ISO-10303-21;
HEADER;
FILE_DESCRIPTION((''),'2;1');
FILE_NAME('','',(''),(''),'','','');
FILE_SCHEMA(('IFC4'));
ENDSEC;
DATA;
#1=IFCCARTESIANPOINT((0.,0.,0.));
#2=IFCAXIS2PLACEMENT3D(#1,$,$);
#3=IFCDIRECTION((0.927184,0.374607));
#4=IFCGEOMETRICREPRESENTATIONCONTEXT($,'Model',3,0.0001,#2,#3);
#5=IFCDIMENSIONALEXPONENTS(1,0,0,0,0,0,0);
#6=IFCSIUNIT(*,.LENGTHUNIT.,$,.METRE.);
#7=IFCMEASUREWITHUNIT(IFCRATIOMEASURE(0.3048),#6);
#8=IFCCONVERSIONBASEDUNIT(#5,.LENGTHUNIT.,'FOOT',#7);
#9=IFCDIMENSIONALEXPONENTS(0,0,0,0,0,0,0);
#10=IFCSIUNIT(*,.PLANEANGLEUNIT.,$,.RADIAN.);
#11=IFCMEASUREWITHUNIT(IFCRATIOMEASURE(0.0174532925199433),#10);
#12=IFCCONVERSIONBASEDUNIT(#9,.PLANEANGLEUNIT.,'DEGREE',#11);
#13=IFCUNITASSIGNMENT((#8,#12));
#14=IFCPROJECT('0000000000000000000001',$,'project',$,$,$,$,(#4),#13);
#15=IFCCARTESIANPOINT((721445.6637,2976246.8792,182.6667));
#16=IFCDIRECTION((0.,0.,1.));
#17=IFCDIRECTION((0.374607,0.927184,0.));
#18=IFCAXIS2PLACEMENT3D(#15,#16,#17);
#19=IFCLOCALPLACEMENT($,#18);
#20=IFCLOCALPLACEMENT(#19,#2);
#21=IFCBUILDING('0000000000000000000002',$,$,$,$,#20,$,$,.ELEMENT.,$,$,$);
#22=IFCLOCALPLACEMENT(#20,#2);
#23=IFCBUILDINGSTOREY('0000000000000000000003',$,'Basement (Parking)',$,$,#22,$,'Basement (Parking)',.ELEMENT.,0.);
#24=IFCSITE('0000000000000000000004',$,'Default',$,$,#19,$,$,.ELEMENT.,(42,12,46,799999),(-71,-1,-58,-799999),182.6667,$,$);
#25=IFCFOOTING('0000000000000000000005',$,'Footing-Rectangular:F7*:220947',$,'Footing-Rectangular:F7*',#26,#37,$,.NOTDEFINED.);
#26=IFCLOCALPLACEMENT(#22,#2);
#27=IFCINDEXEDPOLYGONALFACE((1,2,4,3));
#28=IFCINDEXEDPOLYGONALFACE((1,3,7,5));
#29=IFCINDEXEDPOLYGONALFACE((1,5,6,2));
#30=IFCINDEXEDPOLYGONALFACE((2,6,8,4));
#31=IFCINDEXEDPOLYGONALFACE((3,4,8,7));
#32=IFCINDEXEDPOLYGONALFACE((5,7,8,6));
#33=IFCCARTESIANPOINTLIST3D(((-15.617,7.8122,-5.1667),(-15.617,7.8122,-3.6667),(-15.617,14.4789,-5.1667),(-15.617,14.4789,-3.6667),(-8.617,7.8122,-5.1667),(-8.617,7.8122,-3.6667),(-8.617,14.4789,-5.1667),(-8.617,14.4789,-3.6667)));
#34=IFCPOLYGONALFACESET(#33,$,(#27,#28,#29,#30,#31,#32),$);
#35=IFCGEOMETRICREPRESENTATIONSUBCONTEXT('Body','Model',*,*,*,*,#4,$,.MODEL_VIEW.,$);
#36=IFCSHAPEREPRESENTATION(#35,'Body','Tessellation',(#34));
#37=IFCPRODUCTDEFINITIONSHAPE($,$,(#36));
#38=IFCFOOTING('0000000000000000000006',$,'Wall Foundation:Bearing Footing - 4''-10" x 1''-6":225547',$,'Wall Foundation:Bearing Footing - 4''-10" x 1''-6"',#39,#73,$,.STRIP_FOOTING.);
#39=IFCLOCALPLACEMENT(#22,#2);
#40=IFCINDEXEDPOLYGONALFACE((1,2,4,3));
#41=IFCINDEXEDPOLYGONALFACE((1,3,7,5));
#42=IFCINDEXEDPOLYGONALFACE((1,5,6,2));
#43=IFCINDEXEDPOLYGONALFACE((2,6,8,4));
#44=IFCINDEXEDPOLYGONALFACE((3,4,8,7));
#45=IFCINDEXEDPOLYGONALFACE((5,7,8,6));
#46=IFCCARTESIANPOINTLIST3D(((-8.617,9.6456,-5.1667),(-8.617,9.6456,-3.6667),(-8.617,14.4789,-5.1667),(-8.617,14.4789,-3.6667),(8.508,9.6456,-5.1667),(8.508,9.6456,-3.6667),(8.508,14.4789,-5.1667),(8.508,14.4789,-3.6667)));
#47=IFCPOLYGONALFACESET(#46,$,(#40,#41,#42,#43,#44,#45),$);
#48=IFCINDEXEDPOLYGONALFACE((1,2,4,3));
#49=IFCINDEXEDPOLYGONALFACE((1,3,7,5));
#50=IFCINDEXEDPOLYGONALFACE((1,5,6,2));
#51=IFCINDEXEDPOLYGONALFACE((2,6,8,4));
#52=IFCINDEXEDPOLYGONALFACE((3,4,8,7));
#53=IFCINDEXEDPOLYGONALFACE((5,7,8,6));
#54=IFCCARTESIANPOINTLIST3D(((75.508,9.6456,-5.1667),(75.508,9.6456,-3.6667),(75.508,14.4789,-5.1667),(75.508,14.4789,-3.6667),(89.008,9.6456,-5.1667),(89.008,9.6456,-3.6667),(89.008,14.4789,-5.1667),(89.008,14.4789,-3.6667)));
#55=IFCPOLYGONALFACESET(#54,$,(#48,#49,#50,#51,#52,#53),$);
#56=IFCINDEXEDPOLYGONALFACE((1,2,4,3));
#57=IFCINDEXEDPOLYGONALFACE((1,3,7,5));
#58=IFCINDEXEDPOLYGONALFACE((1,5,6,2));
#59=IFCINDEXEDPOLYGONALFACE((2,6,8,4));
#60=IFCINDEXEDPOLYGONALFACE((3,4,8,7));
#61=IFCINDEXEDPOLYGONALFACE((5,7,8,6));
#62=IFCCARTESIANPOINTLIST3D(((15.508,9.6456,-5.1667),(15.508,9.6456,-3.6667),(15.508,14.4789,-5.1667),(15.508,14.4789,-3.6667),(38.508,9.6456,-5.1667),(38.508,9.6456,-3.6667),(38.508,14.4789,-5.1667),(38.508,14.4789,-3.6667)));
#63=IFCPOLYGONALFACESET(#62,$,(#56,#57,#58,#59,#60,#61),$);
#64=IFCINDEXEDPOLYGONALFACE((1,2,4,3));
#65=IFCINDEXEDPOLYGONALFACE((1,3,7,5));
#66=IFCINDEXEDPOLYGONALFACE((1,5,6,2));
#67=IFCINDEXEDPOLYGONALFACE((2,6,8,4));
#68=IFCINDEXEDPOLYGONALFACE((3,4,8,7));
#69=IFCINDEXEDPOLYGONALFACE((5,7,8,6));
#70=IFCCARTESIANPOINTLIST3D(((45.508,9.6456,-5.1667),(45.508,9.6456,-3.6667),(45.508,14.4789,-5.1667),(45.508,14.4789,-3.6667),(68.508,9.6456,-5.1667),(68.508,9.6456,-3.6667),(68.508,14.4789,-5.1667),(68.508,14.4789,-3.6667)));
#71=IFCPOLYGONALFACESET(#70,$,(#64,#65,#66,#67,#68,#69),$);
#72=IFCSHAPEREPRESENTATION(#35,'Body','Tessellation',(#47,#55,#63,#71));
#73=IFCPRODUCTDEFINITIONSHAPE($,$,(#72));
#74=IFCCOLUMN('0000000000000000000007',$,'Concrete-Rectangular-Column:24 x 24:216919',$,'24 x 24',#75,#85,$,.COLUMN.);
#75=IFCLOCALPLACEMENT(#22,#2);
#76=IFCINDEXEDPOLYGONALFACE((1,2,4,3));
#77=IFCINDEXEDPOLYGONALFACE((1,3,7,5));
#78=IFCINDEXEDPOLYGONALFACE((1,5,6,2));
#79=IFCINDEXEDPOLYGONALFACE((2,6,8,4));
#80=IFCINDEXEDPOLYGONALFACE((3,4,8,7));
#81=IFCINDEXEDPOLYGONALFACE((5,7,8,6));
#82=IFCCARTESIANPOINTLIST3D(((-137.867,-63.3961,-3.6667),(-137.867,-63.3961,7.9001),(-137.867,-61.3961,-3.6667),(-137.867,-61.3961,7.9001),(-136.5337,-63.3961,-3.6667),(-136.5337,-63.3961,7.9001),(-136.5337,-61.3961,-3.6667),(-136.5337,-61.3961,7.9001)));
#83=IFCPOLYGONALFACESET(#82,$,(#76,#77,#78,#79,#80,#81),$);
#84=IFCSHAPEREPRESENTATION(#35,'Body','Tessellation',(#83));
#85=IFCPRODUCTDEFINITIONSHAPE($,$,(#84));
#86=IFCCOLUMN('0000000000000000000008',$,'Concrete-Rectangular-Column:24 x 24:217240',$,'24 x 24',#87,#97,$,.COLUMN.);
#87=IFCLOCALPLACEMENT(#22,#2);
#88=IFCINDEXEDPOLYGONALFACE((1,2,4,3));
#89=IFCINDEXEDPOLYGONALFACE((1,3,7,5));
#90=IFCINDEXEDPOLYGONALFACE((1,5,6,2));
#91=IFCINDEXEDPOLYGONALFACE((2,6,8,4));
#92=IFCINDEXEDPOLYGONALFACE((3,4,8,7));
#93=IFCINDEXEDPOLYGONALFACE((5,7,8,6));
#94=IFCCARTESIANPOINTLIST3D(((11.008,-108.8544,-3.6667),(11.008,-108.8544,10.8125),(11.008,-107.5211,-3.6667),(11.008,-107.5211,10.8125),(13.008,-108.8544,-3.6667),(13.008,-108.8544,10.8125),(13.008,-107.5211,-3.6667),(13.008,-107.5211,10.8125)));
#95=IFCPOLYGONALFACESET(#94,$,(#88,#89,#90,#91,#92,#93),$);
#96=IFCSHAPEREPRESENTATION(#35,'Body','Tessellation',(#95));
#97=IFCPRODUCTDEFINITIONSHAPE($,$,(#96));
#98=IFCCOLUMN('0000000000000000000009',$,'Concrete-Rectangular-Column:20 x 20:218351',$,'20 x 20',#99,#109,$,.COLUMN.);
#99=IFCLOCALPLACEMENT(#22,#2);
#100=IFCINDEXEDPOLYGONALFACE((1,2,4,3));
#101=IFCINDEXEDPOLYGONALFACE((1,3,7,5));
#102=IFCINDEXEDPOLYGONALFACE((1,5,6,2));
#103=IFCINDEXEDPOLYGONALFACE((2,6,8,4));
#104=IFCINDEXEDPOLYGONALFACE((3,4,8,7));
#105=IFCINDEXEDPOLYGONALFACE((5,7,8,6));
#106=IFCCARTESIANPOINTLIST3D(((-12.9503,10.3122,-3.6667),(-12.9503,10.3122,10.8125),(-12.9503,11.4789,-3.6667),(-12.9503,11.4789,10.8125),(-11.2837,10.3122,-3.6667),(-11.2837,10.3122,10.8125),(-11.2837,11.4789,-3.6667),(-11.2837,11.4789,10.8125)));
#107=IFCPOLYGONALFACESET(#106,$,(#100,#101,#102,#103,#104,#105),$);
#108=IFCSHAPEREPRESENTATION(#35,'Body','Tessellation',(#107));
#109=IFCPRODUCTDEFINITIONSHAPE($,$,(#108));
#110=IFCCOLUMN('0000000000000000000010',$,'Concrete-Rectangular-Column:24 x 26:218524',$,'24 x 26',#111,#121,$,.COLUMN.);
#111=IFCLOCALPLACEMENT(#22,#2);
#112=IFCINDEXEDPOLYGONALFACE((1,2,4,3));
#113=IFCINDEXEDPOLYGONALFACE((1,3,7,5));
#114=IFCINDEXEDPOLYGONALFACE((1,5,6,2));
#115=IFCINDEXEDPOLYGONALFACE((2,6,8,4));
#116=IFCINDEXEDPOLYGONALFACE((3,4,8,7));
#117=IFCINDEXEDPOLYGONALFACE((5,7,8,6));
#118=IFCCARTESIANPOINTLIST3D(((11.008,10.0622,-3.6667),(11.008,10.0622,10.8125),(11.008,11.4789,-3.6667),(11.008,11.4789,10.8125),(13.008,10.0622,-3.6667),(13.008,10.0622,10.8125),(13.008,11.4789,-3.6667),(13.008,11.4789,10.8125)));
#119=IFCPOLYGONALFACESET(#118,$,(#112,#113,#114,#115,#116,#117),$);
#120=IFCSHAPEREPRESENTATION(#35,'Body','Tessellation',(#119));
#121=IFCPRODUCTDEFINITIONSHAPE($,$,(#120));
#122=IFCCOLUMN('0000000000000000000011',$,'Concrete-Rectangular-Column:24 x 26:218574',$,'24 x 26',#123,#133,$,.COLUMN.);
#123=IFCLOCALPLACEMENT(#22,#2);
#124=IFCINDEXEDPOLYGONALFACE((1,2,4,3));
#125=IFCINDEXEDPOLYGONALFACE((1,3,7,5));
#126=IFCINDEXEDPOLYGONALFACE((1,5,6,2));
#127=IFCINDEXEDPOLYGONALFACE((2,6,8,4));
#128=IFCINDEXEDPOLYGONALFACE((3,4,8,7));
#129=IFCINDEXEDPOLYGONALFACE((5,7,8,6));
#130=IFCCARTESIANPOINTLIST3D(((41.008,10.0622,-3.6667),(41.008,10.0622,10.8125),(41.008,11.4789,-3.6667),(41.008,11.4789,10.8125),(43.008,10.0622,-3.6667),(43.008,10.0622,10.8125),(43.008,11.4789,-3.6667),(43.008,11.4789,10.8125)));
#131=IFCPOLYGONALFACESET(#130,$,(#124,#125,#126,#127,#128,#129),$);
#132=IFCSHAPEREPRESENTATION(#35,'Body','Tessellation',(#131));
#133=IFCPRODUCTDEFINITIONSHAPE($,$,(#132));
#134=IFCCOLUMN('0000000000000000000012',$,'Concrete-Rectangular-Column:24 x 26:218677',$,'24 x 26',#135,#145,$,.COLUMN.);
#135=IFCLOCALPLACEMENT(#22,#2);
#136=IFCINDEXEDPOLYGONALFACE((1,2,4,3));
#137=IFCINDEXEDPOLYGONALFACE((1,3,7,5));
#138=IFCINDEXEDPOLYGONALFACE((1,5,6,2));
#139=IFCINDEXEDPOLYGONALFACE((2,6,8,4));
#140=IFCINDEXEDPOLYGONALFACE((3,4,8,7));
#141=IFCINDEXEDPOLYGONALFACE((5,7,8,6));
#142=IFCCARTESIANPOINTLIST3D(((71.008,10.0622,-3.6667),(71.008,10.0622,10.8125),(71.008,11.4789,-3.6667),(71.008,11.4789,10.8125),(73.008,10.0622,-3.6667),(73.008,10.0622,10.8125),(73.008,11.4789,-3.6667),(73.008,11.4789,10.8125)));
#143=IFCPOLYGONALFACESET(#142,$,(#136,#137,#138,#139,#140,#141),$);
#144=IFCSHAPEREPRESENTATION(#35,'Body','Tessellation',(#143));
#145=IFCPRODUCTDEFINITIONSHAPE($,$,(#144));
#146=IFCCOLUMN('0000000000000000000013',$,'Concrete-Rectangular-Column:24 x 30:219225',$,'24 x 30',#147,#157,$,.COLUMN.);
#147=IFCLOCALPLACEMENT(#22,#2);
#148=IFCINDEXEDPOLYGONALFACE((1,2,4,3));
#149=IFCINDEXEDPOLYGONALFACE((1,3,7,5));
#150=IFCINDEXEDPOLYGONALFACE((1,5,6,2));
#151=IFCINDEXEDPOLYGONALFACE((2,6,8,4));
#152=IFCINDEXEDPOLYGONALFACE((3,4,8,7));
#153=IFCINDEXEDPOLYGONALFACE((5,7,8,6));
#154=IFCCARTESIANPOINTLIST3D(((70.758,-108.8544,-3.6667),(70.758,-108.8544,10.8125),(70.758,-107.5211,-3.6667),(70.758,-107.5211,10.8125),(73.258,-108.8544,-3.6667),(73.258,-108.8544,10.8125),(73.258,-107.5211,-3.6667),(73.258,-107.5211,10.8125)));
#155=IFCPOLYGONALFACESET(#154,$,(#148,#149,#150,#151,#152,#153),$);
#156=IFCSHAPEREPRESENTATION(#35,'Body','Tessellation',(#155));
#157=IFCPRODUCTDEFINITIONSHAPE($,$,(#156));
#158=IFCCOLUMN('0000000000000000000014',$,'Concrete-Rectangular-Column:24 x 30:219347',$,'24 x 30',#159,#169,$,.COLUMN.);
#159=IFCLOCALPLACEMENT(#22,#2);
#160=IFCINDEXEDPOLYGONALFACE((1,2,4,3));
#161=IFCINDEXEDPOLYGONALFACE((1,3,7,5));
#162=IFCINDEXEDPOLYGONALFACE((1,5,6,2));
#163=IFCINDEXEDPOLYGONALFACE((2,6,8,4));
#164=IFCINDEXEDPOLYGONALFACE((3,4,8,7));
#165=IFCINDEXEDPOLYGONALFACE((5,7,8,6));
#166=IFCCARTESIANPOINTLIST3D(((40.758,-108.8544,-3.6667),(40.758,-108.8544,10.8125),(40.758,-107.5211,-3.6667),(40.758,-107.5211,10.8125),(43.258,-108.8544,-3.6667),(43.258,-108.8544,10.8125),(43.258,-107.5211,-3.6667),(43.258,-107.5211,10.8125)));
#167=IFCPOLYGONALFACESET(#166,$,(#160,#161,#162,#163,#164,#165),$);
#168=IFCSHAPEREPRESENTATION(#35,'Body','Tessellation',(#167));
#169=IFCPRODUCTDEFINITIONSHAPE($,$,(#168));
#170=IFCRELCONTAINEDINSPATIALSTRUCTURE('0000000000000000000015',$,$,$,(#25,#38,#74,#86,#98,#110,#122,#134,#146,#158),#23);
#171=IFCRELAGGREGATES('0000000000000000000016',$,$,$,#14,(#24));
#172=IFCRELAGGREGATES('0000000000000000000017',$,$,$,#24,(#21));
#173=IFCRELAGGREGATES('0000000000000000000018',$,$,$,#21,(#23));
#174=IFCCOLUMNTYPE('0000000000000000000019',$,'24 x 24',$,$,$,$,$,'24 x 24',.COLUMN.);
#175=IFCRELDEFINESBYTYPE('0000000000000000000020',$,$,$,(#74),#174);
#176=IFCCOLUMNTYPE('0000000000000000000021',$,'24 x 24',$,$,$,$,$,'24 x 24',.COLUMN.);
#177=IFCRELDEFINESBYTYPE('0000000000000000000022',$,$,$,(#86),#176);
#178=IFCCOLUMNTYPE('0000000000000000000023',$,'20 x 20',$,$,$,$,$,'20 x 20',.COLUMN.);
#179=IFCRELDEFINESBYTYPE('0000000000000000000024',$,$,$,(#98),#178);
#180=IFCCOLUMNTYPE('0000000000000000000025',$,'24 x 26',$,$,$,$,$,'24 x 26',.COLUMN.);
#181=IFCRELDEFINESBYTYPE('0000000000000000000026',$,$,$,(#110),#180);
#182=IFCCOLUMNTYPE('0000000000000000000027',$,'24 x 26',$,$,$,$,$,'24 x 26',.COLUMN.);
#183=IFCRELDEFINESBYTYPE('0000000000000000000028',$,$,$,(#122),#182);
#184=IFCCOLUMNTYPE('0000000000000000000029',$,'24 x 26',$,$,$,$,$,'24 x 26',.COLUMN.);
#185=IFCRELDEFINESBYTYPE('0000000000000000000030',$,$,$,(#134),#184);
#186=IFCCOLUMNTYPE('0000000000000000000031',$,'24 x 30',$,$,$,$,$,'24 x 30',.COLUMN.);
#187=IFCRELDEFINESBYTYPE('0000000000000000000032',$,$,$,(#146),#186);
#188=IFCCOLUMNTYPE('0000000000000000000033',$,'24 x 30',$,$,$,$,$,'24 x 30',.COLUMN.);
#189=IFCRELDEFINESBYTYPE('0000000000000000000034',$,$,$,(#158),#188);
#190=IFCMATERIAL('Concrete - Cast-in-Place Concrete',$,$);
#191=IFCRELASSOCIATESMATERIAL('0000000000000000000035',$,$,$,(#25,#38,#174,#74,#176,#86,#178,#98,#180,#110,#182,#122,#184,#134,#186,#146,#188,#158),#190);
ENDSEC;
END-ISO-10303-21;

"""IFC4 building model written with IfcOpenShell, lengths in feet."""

from ifc_helpers import new_model, entity, si_unit, converted_unit, direction, frame, frame_2d, origin, origin_2d_with_axis, place, context, subcontext, project, spatial, rectangle, extrude, source, transform, mapped, material, type_object, type_shapes, element, save


model = new_model("IFC4")

# Units and contexts
model_context = context("Model", 3, precision=0.0001, world=origin(), true_north=direction((0.927184, 0.374607)))
body_context = subcontext(model_context, "Body", "Model", "MODEL_VIEW")
ifc_project = project(units=[converted_unit("LENGTHUNIT", "FOOT", entity("IfcRatioMeasure", 0.3048), si_unit("LENGTHUNIT", "METRE"), dimensions=[1, 0, 0, 0, 0, 0, 0]), converted_unit("PLANEANGLEUNIT", "DEGREE", entity("IfcRatioMeasure", 0.0174532925199433), si_unit("PLANEANGLEUNIT", "RADIAN"), dimensions=[0, 0, 0, 0, 0, 0, 0])], contexts=[model_context])

# Site, building, storey
site_placement = place(None, frame((721445.6637, 2976246.8792, 182.6667), z_axis=(0.0, 0.0, 1.0), x_axis=(0.374607, 0.927184, 0.0)))
site = spatial("IfcSite", under=ifc_project, at=site_placement, Name="Default", CompositionType="ELEMENT", RefLatitude=(42, 12, 46, 799999), RefLongitude=(-71, -1, -58, -799999), RefElevation=182.6667)
building_placement = place(site_placement, origin())
building = spatial("IfcBuilding", under=site, at=building_placement, CompositionType="ELEMENT")
storey_placement = place(building_placement, origin())
storey = spatial("IfcBuildingStorey", under=building, at=storey_placement, Name="Basement (Parking)", LongName="Basement (Parking)", CompositionType="ELEMENT", Elevation=0.0)

# Footings
ifc_material_1 = material(Name="Concrete - Cast-in-Place Concrete")
footing_1_placement = place(storey_placement, frame((-15.617, 7.8122, -5.1667)))
element("IfcFooting", 1, at=footing_1_placement, inside=storey, material=ifc_material_1, Name="Footing-Rectangular:F7*:220947", ObjectType="Footing-Rectangular:F7*", PredefinedType="NOTDEFINED", context=body_context, shape_type="SweptSolid", body=[
    extrude(rectangle(XDim=6.6667, YDim=7.0, at=frame_2d((-0.5, 0.0), x_axis=(1.0, 0.0))), frame((3.5, 2.8333, 0.0), z_axis=(0.0, 0.0, 1.0), x_axis=(0.0, -1.0, 0.0)), (0.0, 0.0, 1.0), 1.5),
])
footing_2_placement = place(storey_placement, frame((-8.617, 9.6456, -5.1667)))
element("IfcFooting", 2, at=footing_2_placement, inside=storey, material=ifc_material_1, Name="Wall Foundation:Bearing Footing - 4'-10\" x 1'-6\":225547", ObjectType="Wall Foundation:Bearing Footing - 4'-10\" x 1'-6\"", PredefinedType="STRIP_FOOTING", context=body_context, shape_type="SweptSolid", body=[
    extrude(rectangle(XDim=17.125, YDim=4.8333, at=origin_2d_with_axis()), frame((8.5625, 2.4167, 0.0)), (0.0, 0.0, 1.0), 1.5),
    extrude(rectangle(XDim=13.5, YDim=4.8333, at=frame_2d((0.0, 0.0), x_axis=(1.0, 0.0))), frame((90.875, 2.4167, 0.0), z_axis=(0.0, 0.0, 1.0), x_axis=(-1.0, 0.0, 0.0)), (0.0, 0.0, 1.0), 1.5),
    extrude(rectangle(XDim=23.0, YDim=4.8333, at=origin_2d_with_axis()), frame((35.625, 2.4167, 0.0)), (0.0, 0.0, 1.0), 1.5),
    extrude(rectangle(XDim=23.0, YDim=4.8333, at=frame_2d((0.0, 0.0), x_axis=(1.0, 0.0))), frame((65.625, 2.4167, 0.0)), (0.0, 0.0, 1.0), 1.5),
])

# Columns
column_type_1 = type_object("IfcColumnType", Name="24 x 24", ElementType="24 x 24", PredefinedType="COLUMN", material=ifc_material_1)
shared_shape_1 = source(origin(), body_context, "Body", "SweptSolid", [
    extrude(rectangle(XDim=2.0, YDim=1.3333, at=frame_2d((0.0, 0.0), x_axis=(1.0, 0.0))), frame((-137.2003, -62.3961, -3.6667), z_axis=(0.0, 0.0, 1.0), x_axis=(0.0, -1.0, 0.0)), (0.0, 0.0, 1.0), 11.5667),
])
type_shapes(column_type_1, [shared_shape_1])
column_1_placement = place(storey_placement, origin())
element("IfcColumn", 3, at=column_1_placement, inside=storey, type_object=column_type_1, material=ifc_material_1, Name="Concrete-Rectangular-Column:24 x 24:216919", ObjectType="24 x 24", PredefinedType="COLUMN", context=body_context, shape_type="MappedRepresentation", body=[
    mapped(shared_shape_1, transform((0.0, 0.0, 0.0), scale=1.0)),
])
column_type_2 = type_object("IfcColumnType", Name="24 x 24", ElementType="24 x 24", PredefinedType="COLUMN", material=ifc_material_1)
shared_shape_2 = source(origin(), body_context, "Body", "SweptSolid", [
    extrude(rectangle(XDim=1.3333, YDim=2.0, at=frame_2d((0.0, 0.0), x_axis=(1.0, 0.0))), frame((12.008, -108.1878, -3.6667), z_axis=(0.0, 0.0, 1.0), x_axis=(0.0, -1.0, 0.0)), (0.0, 0.0, 1.0), 14.4792),
])
type_shapes(column_type_2, [shared_shape_2])
column_2_placement = place(storey_placement, origin())
element("IfcColumn", 4, at=column_2_placement, inside=storey, type_object=column_type_2, material=ifc_material_1, Name="Concrete-Rectangular-Column:24 x 24:217240", ObjectType="24 x 24", PredefinedType="COLUMN", context=body_context, shape_type="MappedRepresentation", body=[
    mapped(shared_shape_2, transform((0.0, 0.0, 0.0), scale=1.0)),
])
column_type_3 = type_object("IfcColumnType", Name="20 x 20", ElementType="20 x 20", PredefinedType="COLUMN", material=ifc_material_1)
shared_shape_3 = source(origin(), body_context, "Body", "SweptSolid", [
    extrude(rectangle(XDim=1.1667, YDim=1.6667, at=frame_2d((0.0, 0.0), x_axis=(1.0, 0.0))), frame((-12.117, 10.8956, -3.6667), z_axis=(0.0, 0.0, 1.0), x_axis=(0.0, -1.0, 0.0)), (0.0, 0.0, 1.0), 14.4792),
])
type_shapes(column_type_3, [shared_shape_3])
column_3_placement = place(storey_placement, origin())
element("IfcColumn", 5, at=column_3_placement, inside=storey, type_object=column_type_3, material=ifc_material_1, Name="Concrete-Rectangular-Column:20 x 20:218351", ObjectType="20 x 20", PredefinedType="COLUMN", context=body_context, shape_type="MappedRepresentation", body=[
    mapped(shared_shape_3, transform((0.0, 0.0, 0.0), scale=1.0)),
])
column_type_4 = type_object("IfcColumnType", Name="24 x 26", ElementType="24 x 26", PredefinedType="COLUMN", material=ifc_material_1)
shared_shape_4 = source(origin(), body_context, "Body", "SweptSolid", [
    extrude(rectangle(XDim=1.4167, YDim=2.0, at=frame_2d((0.0, 0.0), x_axis=(1.0, 0.0))), frame((12.008, 10.7706, -3.6667), z_axis=(0.0, 0.0, 1.0), x_axis=(0.0, -1.0, 0.0)), (0.0, 0.0, 1.0), 14.4792),
])
type_shapes(column_type_4, [shared_shape_4])
column_4_placement = place(storey_placement, origin())
element("IfcColumn", 6, at=column_4_placement, inside=storey, type_object=column_type_4, material=ifc_material_1, Name="Concrete-Rectangular-Column:24 x 26:218524", ObjectType="24 x 26", PredefinedType="COLUMN", context=body_context, shape_type="MappedRepresentation", body=[
    mapped(shared_shape_4, transform((0.0, 0.0, 0.0), scale=1.0)),
])
column_type_5 = type_object("IfcColumnType", Name="24 x 26", ElementType="24 x 26", PredefinedType="COLUMN", material=ifc_material_1)
shared_shape_5 = source(origin(), body_context, "Body", "SweptSolid", [
    extrude(rectangle(XDim=1.4167, YDim=2.0, at=frame_2d((0.0, 0.0), x_axis=(1.0, 0.0))), frame((42.008, 10.7706, -3.6667), z_axis=(0.0, 0.0, 1.0), x_axis=(0.0, -1.0, 0.0)), (0.0, 0.0, 1.0), 14.4792),
])
type_shapes(column_type_5, [shared_shape_5])
column_5_placement = place(storey_placement, origin())
element("IfcColumn", 7, at=column_5_placement, inside=storey, type_object=column_type_5, material=ifc_material_1, Name="Concrete-Rectangular-Column:24 x 26:218574", ObjectType="24 x 26", PredefinedType="COLUMN", context=body_context, shape_type="MappedRepresentation", body=[
    mapped(shared_shape_5, transform((0.0, 0.0, 0.0), scale=1.0)),
])
column_type_6 = type_object("IfcColumnType", Name="24 x 26", ElementType="24 x 26", PredefinedType="COLUMN", material=ifc_material_1)
shared_shape_6 = source(origin(), body_context, "Body", "SweptSolid", [
    extrude(rectangle(XDim=1.4167, YDim=2.0, at=frame_2d((0.0, 0.0), x_axis=(1.0, 0.0))), frame((72.008, 10.7706, -3.6667), z_axis=(0.0, 0.0, 1.0), x_axis=(0.0, -1.0, 0.0)), (0.0, 0.0, 1.0), 14.4792),
])
type_shapes(column_type_6, [shared_shape_6])
column_6_placement = place(storey_placement, origin())
element("IfcColumn", 8, at=column_6_placement, inside=storey, type_object=column_type_6, material=ifc_material_1, Name="Concrete-Rectangular-Column:24 x 26:218677", ObjectType="24 x 26", PredefinedType="COLUMN", context=body_context, shape_type="MappedRepresentation", body=[
    mapped(shared_shape_6, transform((0.0, 0.0, 0.0), scale=1.0)),
])
column_type_7 = type_object("IfcColumnType", Name="24 x 30", ElementType="24 x 30", PredefinedType="COLUMN", material=ifc_material_1)
shared_shape_7 = source(origin(), body_context, "Body", "SweptSolid", [
    extrude(rectangle(XDim=1.3333, YDim=2.5, at=origin_2d_with_axis()), frame((72.008, -108.1878, -3.6667), z_axis=(0.0, 0.0, 1.0), x_axis=(0.0, -1.0, 0.0)), (0.0, 0.0, 1.0), 14.4792),
])
type_shapes(column_type_7, [shared_shape_7])
column_7_placement = place(storey_placement, origin())
element("IfcColumn", 9, at=column_7_placement, inside=storey, type_object=column_type_7, material=ifc_material_1, Name="Concrete-Rectangular-Column:24 x 30:219225", ObjectType="24 x 30", PredefinedType="COLUMN", context=body_context, shape_type="MappedRepresentation", body=[
    mapped(shared_shape_7, transform((0.0, 0.0, 0.0), scale=1.0)),
])
column_type_8 = type_object("IfcColumnType", Name="24 x 30", ElementType="24 x 30", PredefinedType="COLUMN", material=ifc_material_1)
shared_shape_8 = source(origin(), body_context, "Body", "SweptSolid", [
    extrude(rectangle(XDim=1.3333, YDim=2.5, at=frame_2d((0.0, 0.0), x_axis=(1.0, 0.0))), frame((42.008, -108.1878, -3.6667), z_axis=(0.0, 0.0, 1.0), x_axis=(0.0, -1.0, 0.0)), (0.0, 0.0, 1.0), 14.4792),
])
type_shapes(column_type_8, [shared_shape_8])
column_8_placement = place(storey_placement, origin())
element("IfcColumn", 10, at=column_8_placement, inside=storey, type_object=column_type_8, material=ifc_material_1, Name="Concrete-Rectangular-Column:24 x 30:219347", ObjectType="24 x 30", PredefinedType="COLUMN", context=body_context, shape_type="MappedRepresentation", body=[
    mapped(shared_shape_8, transform((0.0, 0.0, 0.0), scale=1.0)),
])

save(model, "model.ifc")
